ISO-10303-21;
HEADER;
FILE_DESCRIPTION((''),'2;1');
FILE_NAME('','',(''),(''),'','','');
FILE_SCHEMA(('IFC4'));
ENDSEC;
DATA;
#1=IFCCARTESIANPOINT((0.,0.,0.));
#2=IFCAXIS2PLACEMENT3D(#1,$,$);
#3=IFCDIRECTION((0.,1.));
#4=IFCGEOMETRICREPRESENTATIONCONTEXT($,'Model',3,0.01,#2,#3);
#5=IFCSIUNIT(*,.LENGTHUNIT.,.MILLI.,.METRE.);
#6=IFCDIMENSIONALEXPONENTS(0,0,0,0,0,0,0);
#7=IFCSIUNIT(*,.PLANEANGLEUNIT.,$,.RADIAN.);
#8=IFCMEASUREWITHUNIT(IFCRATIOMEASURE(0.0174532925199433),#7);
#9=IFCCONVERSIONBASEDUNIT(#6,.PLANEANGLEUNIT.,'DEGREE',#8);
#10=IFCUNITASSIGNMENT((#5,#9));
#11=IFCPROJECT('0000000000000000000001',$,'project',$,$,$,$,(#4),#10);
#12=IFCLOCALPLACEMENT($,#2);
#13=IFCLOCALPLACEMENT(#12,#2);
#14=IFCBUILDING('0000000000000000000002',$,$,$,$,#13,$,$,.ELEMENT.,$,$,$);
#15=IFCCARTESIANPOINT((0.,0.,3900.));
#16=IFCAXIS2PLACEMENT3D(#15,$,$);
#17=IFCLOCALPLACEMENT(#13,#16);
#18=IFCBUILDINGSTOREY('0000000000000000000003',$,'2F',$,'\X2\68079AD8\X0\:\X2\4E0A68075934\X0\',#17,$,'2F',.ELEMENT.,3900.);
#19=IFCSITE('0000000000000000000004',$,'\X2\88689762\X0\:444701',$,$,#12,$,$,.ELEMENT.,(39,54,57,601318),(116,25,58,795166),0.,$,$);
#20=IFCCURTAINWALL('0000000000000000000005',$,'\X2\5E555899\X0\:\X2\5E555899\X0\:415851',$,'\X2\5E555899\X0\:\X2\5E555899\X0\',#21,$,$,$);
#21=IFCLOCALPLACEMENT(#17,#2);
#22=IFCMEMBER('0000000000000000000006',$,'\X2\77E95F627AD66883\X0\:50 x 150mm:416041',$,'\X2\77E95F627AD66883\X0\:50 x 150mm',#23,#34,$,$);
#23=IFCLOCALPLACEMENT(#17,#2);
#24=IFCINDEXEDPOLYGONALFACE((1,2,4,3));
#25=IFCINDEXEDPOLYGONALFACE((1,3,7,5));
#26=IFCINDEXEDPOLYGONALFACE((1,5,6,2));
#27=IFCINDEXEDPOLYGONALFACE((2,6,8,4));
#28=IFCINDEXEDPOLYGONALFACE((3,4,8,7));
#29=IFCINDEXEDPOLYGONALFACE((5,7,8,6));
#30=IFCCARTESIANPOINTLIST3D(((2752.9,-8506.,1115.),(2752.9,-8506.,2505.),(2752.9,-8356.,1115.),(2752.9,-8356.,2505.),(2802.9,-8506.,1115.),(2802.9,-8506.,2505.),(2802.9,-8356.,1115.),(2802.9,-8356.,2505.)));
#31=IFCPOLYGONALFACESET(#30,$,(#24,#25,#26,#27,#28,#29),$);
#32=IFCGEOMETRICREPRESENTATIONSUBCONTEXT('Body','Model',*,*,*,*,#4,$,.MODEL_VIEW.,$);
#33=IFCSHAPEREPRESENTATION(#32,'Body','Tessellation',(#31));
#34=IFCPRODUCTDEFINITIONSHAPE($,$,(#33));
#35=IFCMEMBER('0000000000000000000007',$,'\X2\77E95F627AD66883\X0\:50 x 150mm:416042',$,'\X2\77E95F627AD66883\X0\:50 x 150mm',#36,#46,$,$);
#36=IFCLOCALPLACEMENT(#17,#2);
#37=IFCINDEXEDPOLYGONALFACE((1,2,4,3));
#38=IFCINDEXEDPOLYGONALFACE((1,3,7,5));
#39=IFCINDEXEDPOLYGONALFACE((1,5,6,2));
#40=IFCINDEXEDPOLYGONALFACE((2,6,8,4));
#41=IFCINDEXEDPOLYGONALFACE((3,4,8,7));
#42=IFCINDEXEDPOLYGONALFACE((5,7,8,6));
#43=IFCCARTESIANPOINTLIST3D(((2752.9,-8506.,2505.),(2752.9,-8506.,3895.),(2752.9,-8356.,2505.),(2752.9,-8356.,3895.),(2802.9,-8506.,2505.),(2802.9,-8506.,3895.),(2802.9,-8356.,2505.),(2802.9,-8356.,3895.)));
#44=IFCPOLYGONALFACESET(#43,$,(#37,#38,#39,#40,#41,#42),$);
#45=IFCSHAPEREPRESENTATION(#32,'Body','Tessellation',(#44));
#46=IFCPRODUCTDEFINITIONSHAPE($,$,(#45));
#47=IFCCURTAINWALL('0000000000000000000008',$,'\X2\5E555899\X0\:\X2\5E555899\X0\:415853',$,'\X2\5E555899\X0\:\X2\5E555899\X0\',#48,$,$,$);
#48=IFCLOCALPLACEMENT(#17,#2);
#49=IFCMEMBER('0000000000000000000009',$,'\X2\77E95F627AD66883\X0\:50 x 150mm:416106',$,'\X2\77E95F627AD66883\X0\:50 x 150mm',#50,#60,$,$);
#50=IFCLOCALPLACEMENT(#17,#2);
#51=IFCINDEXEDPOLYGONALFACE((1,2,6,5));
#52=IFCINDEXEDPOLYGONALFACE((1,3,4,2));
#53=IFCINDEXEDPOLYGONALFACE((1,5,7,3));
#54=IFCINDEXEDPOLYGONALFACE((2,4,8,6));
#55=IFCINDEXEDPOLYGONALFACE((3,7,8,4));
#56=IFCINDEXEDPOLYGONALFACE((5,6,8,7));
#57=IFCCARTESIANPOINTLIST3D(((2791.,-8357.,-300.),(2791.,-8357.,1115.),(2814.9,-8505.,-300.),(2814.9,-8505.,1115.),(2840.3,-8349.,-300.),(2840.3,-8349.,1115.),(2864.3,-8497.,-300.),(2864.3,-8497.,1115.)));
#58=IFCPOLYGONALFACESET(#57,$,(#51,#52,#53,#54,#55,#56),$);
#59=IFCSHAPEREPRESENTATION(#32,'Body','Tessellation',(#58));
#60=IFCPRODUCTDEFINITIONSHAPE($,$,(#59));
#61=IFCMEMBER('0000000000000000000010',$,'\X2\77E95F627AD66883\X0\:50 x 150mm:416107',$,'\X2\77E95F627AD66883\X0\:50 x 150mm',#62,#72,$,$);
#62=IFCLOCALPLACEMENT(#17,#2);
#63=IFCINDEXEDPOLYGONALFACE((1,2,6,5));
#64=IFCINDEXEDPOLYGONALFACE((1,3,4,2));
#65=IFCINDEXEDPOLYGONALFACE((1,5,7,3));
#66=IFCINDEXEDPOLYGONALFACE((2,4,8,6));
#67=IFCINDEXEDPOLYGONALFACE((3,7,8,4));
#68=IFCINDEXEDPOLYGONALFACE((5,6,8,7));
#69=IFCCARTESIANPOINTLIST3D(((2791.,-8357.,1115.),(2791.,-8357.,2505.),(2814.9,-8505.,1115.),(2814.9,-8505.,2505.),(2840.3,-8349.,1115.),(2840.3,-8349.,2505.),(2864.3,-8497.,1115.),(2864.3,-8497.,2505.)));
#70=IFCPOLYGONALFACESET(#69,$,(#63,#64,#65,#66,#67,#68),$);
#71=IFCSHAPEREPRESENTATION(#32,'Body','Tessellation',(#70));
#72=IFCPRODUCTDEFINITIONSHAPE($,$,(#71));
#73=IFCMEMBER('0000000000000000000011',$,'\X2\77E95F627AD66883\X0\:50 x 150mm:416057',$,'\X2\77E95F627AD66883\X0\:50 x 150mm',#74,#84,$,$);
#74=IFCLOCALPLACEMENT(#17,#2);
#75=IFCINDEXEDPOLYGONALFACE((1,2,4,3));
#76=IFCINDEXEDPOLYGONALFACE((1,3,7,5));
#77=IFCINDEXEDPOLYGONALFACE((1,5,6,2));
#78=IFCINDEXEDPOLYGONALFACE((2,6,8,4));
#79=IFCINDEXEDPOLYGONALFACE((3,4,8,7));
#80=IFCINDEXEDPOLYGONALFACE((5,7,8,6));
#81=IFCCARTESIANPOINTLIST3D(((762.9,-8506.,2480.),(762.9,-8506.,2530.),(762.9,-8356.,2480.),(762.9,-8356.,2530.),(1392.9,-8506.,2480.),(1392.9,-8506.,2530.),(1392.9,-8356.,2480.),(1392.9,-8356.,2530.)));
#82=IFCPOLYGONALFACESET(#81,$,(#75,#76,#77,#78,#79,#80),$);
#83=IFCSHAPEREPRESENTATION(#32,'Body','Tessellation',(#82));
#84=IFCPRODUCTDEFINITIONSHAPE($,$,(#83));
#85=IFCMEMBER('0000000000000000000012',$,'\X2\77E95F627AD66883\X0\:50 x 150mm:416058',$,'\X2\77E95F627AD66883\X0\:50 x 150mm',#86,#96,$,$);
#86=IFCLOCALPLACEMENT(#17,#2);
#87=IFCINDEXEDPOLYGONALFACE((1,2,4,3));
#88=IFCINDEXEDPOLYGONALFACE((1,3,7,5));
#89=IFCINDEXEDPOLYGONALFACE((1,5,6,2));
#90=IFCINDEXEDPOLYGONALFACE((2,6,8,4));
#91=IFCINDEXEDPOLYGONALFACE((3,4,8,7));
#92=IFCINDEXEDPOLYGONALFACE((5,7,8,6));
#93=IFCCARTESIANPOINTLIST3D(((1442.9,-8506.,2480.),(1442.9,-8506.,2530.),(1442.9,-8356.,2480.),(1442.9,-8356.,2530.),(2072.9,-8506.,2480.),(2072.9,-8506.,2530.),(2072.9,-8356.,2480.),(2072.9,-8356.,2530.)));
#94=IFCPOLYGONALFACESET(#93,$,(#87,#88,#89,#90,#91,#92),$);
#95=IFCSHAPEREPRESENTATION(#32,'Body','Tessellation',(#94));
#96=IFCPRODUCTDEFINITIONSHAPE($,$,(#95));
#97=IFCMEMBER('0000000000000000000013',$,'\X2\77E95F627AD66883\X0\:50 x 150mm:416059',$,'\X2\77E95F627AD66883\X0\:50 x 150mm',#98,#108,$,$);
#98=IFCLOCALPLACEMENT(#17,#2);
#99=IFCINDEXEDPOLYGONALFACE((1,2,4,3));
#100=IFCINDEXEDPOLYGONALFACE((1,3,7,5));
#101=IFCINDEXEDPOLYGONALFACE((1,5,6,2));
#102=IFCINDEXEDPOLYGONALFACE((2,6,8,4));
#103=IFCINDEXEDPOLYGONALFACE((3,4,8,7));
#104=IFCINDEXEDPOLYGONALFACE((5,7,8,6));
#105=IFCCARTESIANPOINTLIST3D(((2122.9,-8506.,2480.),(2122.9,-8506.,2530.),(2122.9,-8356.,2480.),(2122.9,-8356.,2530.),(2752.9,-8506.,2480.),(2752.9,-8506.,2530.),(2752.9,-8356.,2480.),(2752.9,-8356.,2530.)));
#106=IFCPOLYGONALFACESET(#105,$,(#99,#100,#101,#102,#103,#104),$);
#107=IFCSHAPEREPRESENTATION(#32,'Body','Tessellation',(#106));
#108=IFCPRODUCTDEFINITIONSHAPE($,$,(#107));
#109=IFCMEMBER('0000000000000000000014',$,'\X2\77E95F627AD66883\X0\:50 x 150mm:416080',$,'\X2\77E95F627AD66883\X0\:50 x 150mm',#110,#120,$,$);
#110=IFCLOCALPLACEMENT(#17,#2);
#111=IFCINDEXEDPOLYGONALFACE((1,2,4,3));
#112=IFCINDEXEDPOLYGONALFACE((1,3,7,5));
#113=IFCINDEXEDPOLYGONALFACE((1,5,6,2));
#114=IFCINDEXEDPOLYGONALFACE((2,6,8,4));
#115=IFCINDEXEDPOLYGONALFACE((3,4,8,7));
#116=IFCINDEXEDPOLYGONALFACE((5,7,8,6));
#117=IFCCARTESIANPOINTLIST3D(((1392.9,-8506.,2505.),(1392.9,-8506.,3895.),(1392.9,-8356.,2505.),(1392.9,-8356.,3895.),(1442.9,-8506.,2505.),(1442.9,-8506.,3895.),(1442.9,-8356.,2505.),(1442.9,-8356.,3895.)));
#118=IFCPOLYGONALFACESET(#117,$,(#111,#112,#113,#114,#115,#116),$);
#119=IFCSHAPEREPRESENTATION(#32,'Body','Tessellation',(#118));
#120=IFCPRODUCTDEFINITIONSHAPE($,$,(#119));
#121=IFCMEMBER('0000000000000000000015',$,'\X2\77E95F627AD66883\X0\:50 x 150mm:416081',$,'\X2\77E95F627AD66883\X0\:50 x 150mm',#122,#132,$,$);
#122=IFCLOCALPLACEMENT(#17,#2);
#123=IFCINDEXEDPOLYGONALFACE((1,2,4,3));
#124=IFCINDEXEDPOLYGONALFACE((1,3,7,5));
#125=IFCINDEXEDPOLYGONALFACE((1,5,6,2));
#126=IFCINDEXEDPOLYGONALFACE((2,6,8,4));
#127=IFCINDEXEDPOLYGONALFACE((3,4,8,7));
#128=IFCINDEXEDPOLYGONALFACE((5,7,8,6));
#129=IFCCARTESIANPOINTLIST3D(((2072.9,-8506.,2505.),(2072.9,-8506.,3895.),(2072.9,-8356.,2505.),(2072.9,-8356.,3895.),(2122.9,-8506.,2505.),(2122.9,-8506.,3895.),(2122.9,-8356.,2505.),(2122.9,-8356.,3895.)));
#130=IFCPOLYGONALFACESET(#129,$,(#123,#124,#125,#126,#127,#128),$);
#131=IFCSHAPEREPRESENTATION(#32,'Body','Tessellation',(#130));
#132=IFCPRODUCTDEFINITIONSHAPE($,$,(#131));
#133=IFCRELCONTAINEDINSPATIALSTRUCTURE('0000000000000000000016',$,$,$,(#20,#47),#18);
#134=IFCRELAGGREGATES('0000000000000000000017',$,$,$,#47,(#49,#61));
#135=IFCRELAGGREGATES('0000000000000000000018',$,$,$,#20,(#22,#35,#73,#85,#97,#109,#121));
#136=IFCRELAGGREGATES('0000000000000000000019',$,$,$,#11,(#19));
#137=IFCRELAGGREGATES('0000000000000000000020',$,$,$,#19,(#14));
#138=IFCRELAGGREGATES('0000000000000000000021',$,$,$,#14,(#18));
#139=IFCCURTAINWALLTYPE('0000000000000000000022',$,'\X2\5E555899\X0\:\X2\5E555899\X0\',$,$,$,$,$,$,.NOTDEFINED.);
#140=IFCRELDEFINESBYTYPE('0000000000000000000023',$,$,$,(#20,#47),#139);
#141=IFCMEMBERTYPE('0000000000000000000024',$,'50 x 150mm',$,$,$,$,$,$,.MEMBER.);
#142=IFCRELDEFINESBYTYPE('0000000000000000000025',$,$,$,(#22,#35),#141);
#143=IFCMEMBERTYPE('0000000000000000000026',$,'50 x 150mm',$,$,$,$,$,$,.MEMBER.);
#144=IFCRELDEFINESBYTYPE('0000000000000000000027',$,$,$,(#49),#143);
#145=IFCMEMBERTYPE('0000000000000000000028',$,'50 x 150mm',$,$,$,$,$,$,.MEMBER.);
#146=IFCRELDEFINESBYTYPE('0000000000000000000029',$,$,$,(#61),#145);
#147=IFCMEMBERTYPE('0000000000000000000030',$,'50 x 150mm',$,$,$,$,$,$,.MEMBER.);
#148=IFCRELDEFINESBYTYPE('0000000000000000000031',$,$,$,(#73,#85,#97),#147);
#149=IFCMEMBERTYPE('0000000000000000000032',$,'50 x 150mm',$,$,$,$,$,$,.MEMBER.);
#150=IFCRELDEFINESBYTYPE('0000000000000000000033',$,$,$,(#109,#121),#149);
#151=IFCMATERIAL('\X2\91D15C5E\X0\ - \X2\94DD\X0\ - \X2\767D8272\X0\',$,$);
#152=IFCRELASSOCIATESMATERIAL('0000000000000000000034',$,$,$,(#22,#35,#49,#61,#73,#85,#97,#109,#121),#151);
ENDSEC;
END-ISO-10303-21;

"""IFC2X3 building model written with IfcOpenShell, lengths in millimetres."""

from ifc_helpers import new_model, entity, si_unit, converted_unit, direction, frame, origin, origin_2d_with_axis, place, context, subcontext, project, spatial, rectangle, extrude, source, transform, mapped, material, type_object, type_shapes, element, aggregate, save


model = new_model("IFC2X3")

# Units and contexts
model_context = context("Model", 3, precision=0.01, world=origin(), true_north=direction((0.0, 1.0)))
body_context = subcontext(model_context, "Body", "Model", "MODEL_VIEW")
ifc_project = project(units=[si_unit("LENGTHUNIT", "METRE", prefix="MILLI"), converted_unit("PLANEANGLEUNIT", "DEGREE", entity("IfcRatioMeasure", 0.0174532925199433), si_unit("PLANEANGLEUNIT", "RADIAN"), dimensions=[0, 0, 0, 0, 0, 0, 0])], contexts=[model_context])

# Site, building, storey
site_placement = place(None, origin())
site = spatial("IfcSite", under=ifc_project, at=site_placement, Name="表面:444701", CompositionType="ELEMENT", RefLatitude=(39, 54, 57, 601318), RefLongitude=(116, 25, 58, 795166), RefElevation=0.0)
building_placement = place(site_placement, origin())
building = spatial("IfcBuilding", under=site, at=building_placement, CompositionType="ELEMENT")
storey_placement = place(building_placement, frame((0.0, 0.0, 3900.0)))
storey = spatial("IfcBuildingStorey", under=building, at=storey_placement, Name="2F", ObjectType="标高:上标头", LongName="2F", CompositionType="ELEMENT", Elevation=3900.0)

# Curtain wall, members
curtain_wall_type = type_object("IfcCurtainWallType", Name="幕墙:幕墙", PredefinedType="NOTDEFINED")
curtain_wall_1_placement = place(storey_placement, frame((0.0, 0.0, -3900.0)))
curtain_wall_1 = element("IfcCurtainWall", 1, at=curtain_wall_1_placement, inside=storey, type_object=curtain_wall_type, Name="幕墙:幕墙:415851", ObjectType="幕墙:幕墙")
ifc_material_1 = material(Name="金属 - 铝 - 白色")
member_type_1 = type_object("IfcMemberType", Name="50 x 150mm", PredefinedType="MEMBER")
shared_shape_1 = source(origin(), body_context, "Body", "SweptSolid", [
    extrude(rectangle(XDim=150.0, YDim=50.0, at=origin_2d_with_axis()), frame((-25.0, 0.0, -1390.0), z_axis=(0.0, 0.0, 1.0), x_axis=(0.0, -1.0, 0.0)), (0.0, 0.0, 1.0), 1390.0),
])
type_shapes(member_type_1, [shared_shape_1])
member_1_placement = place(storey_placement, frame((2802.9, -8431.0, 1115.0), z_axis=(0.0, 0.0, -1.0), x_axis=(1.0, 0.0, 0.0)))
member_1 = element("IfcMember", 2, at=member_1_placement, type_object=member_type_1, material=ifc_material_1, Name="矩形竖梃:50 x 150mm:416041", ObjectType="矩形竖梃:50 x 150mm", context=body_context, shape_type="MappedRepresentation", body=[
    mapped(shared_shape_1, transform((0.0, 0.0, 0.0), scale=1.0)),
])
member_2_placement = place(storey_placement, frame((2802.9, -8431.0, 2505.0), z_axis=(0.0, 0.0, -1.0), x_axis=(1.0, 0.0, 0.0)))
member_2 = element("IfcMember", 3, at=member_2_placement, type_object=member_type_1, material=ifc_material_1, Name="矩形竖梃:50 x 150mm:416042", ObjectType="矩形竖梃:50 x 150mm", context=body_context, shape_type="MappedRepresentation", body=[
    mapped(shared_shape_1, transform((0.0, 0.0, 0.0), scale=1.0)),
])

# Curtain wall, member
curtain_wall_2_placement = place(storey_placement, frame((0.0, 0.0, -3900.0)))
curtain_wall_2 = element("IfcCurtainWall", 4, at=curtain_wall_2_placement, inside=storey, type_object=curtain_wall_type, Name="幕墙:幕墙:415853", ObjectType="幕墙:幕墙")
member_type_2 = type_object("IfcMemberType", Name="50 x 150mm", PredefinedType="MEMBER")
shared_shape_2 = source(origin(), body_context, "Body", "SweptSolid", [
    extrude(rectangle(XDim=150.0, YDim=50.0, at=origin_2d_with_axis()), frame((-25.0, 0.0, -1415.0), z_axis=(0.0, 0.0, 1.0), x_axis=(0.0, -1.0, 0.0)), (0.0, 0.0, 1.0), 1415.0),
])
type_shapes(member_type_2, [shared_shape_2])
member_3_placement = place(storey_placement, frame((2802.9, -8431.0, 1115.0), z_axis=(0.0, 0.0, 1.0), x_axis=(-0.987172, -0.15966, 0.0)))
member_3 = element("IfcMember", 5, at=member_3_placement, type_object=member_type_2, material=ifc_material_1, Name="矩形竖梃:50 x 150mm:416106", ObjectType="矩形竖梃:50 x 150mm", context=body_context, shape_type="MappedRepresentation", body=[
    mapped(shared_shape_2, transform((0.0, 0.0, 0.0), scale=1.0)),
])

# Members
member_type_3 = type_object("IfcMemberType", Name="50 x 150mm", PredefinedType="MEMBER")
shared_shape_3 = source(origin(), body_context, "Body", "SweptSolid", [
    extrude(rectangle(XDim=150.0, YDim=50.0, at=origin_2d_with_axis()), frame((-25.0, 0.0, -1390.0), z_axis=(0.0, 0.0, 1.0), x_axis=(0.0, -1.0, 0.0)), (0.0, 0.0, 1.0), 1390.0),
])
type_shapes(member_type_3, [shared_shape_3])
member_4_placement = place(storey_placement, frame((2802.9, -8431.0, 2505.0), z_axis=(0.0, 0.0, 1.0), x_axis=(-0.987172, -0.15966, 0.0)))
member_4 = element("IfcMember", 6, at=member_4_placement, type_object=member_type_3, material=ifc_material_1, Name="矩形竖梃:50 x 150mm:416107", ObjectType="矩形竖梃:50 x 150mm", context=body_context, shape_type="MappedRepresentation", body=[
    mapped(shared_shape_3, transform((0.0, 0.0, 0.0), scale=1.0)),
])
aggregate(curtain_wall_2, [member_3, member_4])
member_type_4 = type_object("IfcMemberType", Name="50 x 150mm", PredefinedType="MEMBER")
shared_shape_4 = source(origin(), body_context, "Body", "SweptSolid", [
    extrude(rectangle(XDim=150.0, YDim=50.0, at=origin_2d_with_axis()), frame((0.0, 0.0, -630.0), z_axis=(0.0, 0.0, 1.0), x_axis=(0.0, -1.0, 0.0)), (0.0, 0.0, 1.0), 630.0),
])
type_shapes(member_type_4, [shared_shape_4])
member_5_placement = place(storey_placement, frame((1392.9, -8431.0, 2505.0), z_axis=(1.0, 0.0, 0.0), x_axis=(0.0, 0.0, 1.0)))
member_5 = element("IfcMember", 7, at=member_5_placement, type_object=member_type_4, material=ifc_material_1, Name="矩形竖梃:50 x 150mm:416057", ObjectType="矩形竖梃:50 x 150mm", context=body_context, shape_type="MappedRepresentation", body=[
    mapped(shared_shape_4, transform((0.0, 0.0, 0.0), scale=1.0)),
])
member_6_placement = place(storey_placement, frame((2072.9, -8431.0, 2505.0), z_axis=(1.0, 0.0, 0.0), x_axis=(0.0, 0.0, 1.0)))
member_6 = element("IfcMember", 8, at=member_6_placement, type_object=member_type_4, material=ifc_material_1, Name="矩形竖梃:50 x 150mm:416058", ObjectType="矩形竖梃:50 x 150mm", context=body_context, shape_type="MappedRepresentation", body=[
    mapped(shared_shape_4, transform((0.0, 0.0, 0.0), scale=1.0)),
])
member_7_placement = place(storey_placement, frame((2752.9, -8431.0, 2505.0), z_axis=(1.0, 0.0, 0.0), x_axis=(0.0, 0.0, 1.0)))
member_7 = element("IfcMember", 9, at=member_7_placement, type_object=member_type_4, material=ifc_material_1, Name="矩形竖梃:50 x 150mm:416059", ObjectType="矩形竖梃:50 x 150mm", context=body_context, shape_type="MappedRepresentation", body=[
    mapped(shared_shape_4, transform((0.0, 0.0, 0.0), scale=1.0)),
])
member_type_5 = type_object("IfcMemberType", Name="50 x 150mm", PredefinedType="MEMBER")
shared_shape_5 = source(origin(), body_context, "Body", "SweptSolid", [
    extrude(rectangle(XDim=150.0, YDim=50.0, at=origin_2d_with_axis()), frame((0.0, 0.0, -1390.0), z_axis=(0.0, 0.0, 1.0), x_axis=(0.0, -1.0, 0.0)), (0.0, 0.0, 1.0), 1390.0),
])
type_shapes(member_type_5, [shared_shape_5])
member_8_placement = place(storey_placement, frame((1417.9, -8431.0, 2505.0), z_axis=(0.0, 0.0, -1.0), x_axis=(1.0, 0.0, 0.0)))
member_8 = element("IfcMember", 10, at=member_8_placement, type_object=member_type_5, material=ifc_material_1, Name="矩形竖梃:50 x 150mm:416080", ObjectType="矩形竖梃:50 x 150mm", context=body_context, shape_type="MappedRepresentation", body=[
    mapped(shared_shape_5, transform((0.0, 0.0, 0.0), scale=1.0)),
])
member_9_placement = place(storey_placement, frame((2097.9, -8431.0, 2505.0), z_axis=(0.0, 0.0, -1.0), x_axis=(1.0, 0.0, 0.0)))
member_9 = element("IfcMember", 11, at=member_9_placement, type_object=member_type_5, material=ifc_material_1, Name="矩形竖梃:50 x 150mm:416081", ObjectType="矩形竖梃:50 x 150mm", context=body_context, shape_type="MappedRepresentation", body=[
    mapped(shared_shape_5, transform((0.0, 0.0, 0.0), scale=1.0)),
])

aggregate(curtain_wall_1, [member_1, member_2, member_5, member_6, member_7, member_8, member_9])

save(model, "model.ifc")
